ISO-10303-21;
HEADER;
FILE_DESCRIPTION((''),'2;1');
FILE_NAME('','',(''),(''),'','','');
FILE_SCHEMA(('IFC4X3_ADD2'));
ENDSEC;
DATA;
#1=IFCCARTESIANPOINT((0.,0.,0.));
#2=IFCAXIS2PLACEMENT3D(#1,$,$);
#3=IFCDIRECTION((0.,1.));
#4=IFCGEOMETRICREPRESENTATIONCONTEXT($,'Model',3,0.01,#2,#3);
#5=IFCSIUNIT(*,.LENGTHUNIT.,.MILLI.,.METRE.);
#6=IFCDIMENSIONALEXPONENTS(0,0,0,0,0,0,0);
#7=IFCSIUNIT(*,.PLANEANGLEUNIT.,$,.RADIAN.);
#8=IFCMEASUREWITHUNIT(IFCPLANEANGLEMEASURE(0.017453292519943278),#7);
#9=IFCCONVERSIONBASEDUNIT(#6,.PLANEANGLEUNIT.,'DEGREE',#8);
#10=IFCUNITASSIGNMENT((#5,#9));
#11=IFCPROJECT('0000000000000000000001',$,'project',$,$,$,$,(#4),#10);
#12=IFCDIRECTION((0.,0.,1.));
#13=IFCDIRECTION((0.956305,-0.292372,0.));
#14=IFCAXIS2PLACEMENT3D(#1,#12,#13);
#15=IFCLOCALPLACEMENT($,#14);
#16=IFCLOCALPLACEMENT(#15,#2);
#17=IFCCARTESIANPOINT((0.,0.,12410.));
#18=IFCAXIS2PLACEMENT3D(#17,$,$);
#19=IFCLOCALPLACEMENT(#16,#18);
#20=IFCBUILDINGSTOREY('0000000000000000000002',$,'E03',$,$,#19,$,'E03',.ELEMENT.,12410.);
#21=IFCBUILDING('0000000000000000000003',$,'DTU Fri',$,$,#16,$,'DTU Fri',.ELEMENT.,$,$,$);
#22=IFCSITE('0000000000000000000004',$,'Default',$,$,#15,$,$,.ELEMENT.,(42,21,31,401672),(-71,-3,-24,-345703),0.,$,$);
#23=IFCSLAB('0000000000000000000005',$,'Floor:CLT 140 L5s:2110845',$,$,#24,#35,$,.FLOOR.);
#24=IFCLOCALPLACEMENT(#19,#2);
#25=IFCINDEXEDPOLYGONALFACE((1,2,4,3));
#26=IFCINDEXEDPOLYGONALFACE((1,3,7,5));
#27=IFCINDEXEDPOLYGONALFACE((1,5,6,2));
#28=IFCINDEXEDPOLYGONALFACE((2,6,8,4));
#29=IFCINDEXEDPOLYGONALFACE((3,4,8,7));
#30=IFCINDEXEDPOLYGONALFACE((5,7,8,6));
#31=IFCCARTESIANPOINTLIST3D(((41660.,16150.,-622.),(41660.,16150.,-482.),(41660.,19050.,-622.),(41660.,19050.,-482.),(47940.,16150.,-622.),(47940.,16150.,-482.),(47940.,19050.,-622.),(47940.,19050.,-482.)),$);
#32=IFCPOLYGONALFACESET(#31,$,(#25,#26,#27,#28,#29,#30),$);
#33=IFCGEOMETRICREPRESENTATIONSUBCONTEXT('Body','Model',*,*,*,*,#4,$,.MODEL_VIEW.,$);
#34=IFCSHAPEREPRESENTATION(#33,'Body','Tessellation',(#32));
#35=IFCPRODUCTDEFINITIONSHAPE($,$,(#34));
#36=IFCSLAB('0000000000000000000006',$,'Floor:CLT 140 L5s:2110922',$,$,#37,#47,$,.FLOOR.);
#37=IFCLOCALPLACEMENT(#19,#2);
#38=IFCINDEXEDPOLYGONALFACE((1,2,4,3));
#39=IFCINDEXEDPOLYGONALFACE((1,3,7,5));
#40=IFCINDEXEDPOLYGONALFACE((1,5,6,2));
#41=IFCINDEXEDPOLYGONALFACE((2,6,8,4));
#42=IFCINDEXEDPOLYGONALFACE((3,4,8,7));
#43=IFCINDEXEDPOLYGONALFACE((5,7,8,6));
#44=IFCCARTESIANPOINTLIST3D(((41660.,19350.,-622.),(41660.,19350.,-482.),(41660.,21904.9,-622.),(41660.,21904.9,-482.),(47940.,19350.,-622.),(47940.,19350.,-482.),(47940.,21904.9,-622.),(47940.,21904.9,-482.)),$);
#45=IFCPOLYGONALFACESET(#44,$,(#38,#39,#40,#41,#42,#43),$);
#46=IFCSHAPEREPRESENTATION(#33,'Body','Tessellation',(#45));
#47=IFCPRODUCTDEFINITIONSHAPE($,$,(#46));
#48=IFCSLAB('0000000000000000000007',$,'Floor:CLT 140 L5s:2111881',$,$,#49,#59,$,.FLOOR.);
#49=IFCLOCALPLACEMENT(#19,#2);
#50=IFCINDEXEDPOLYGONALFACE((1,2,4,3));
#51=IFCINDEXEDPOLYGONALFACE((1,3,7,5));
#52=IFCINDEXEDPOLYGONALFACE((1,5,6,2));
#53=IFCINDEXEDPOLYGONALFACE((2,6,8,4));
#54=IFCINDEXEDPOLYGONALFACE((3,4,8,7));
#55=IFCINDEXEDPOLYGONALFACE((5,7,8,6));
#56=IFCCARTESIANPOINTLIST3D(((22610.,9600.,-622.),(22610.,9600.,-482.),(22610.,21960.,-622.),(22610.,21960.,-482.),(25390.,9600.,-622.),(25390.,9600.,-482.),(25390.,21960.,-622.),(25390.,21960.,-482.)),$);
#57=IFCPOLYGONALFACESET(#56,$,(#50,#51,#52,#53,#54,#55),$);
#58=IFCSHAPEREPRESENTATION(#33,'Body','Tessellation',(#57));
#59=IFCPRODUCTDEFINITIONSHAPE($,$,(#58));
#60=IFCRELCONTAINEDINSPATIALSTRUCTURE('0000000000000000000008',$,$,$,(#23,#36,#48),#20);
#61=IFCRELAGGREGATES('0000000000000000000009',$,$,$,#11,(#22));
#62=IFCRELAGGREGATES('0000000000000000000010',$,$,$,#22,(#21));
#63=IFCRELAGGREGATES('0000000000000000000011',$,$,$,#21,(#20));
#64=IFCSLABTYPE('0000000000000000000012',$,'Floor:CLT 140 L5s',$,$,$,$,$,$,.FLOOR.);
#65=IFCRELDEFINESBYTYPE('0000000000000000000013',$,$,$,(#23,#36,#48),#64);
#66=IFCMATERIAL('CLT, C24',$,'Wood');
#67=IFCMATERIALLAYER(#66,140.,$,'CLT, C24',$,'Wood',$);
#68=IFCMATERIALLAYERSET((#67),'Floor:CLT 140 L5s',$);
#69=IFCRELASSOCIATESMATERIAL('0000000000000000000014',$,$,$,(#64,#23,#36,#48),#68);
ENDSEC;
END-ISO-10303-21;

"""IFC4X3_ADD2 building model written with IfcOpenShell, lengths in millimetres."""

from ifc_helpers import new_model, entity, si_unit, converted_unit, direction, frame, frame_2d, origin, origin_2d_with_axis, place, context, subcontext, project, spatial, rectangle, extrude, material, layer, layer_set, layer_usage, type_object, element, save


model = new_model("IFC4X3_ADD2")

# Units and contexts
model_context = context("Model", 3, precision=0.01, world=origin(), true_north=direction((0.0, 1.0)))
body_context = subcontext(model_context, "Body", "Model", "MODEL_VIEW")
ifc_project = project(units=[si_unit("LENGTHUNIT", "METRE", prefix="MILLI"), converted_unit("PLANEANGLEUNIT", "DEGREE", entity("IfcPlaneAngleMeasure", 0.017453292519943278), si_unit("PLANEANGLEUNIT", "RADIAN"), dimensions=[0, 0, 0, 0, 0, 0, 0])], contexts=[model_context])

# Site, building, storey
site_placement = place(None, frame((0.0, 0.0, 0.0), z_axis=(0.0, 0.0, 1.0), x_axis=(0.956305, -0.292372, 0.0)))
site = spatial("IfcSite", under=ifc_project, at=site_placement, Name="Default", CompositionType="ELEMENT", RefLatitude=(42, 21, 31, 401672), RefLongitude=(-71, -3, -24, -345703), RefElevation=0.0)
building_placement = place(site_placement, origin())
building = spatial("IfcBuilding", under=site, at=building_placement, Name="DTU Fri", LongName="DTU Fri", CompositionType="ELEMENT")
storey_placement = place(building_placement, frame((0.0, 0.0, 12410.0)))
storey = spatial("IfcBuildingStorey", under=building, at=storey_placement, Name="E03", LongName="E03", CompositionType="ELEMENT", Elevation=12410.0)

# Slabs
ifc_material = material(Name="CLT, C24", Category="Wood")
ifc_layer_1 = layer(ifc_material, 140.0, Name="CLT, C24", Category="Wood")
ifc_layer_set_1 = layer_set([ifc_layer_1], Name="Floor:CLT 140 L5s")
slab_type_1 = type_object("IfcSlabType", Name="Floor:CLT 140 L5s", PredefinedType="FLOOR", material=ifc_layer_set_1)
ifc_layer_usage_1 = layer_usage(ifc_layer_set_1, "AXIS3", "POSITIVE", 0.0)
slab_1_placement = place(storey_placement, origin())
element("IfcSlab", 1, at=slab_1_placement, inside=storey, type_object=slab_type_1, material=ifc_layer_usage_1, Name="Floor:CLT 140 L5s:2110845", PredefinedType="FLOOR", context=body_context, shape_type="SweptSolid", body=[
    extrude(rectangle(XDim=2900.0, YDim=6280.0, at=frame_2d((0.0, 0.0), x_axis=(1.0, 0.0))), frame((44800.0, 17600.0, -482.0), z_axis=(0.0, 0.0, -1.0), x_axis=(0.0, 1.0, 0.0)), (0.0, 0.0, 1.0), 140.0),
])
ifc_layer_usage_2 = layer_usage(ifc_layer_set_1, "AXIS3", "POSITIVE", 0.0)
slab_2_placement = place(storey_placement, origin())
element("IfcSlab", 2, at=slab_2_placement, inside=storey, type_object=slab_type_1, material=ifc_layer_usage_2, Name="Floor:CLT 140 L5s:2110922", PredefinedType="FLOOR", context=body_context, shape_type="SweptSolid", body=[
    extrude(rectangle(XDim=2554.9, YDim=6280.0, at=origin_2d_with_axis()), frame((44800.0, 20627.4, -482.0), z_axis=(0.0, 0.0, -1.0), x_axis=(0.0, 1.0, 0.0)), (0.0, 0.0, 1.0), 140.0),
])
ifc_layer_usage_3 = layer_usage(ifc_layer_set_1, "AXIS3", "POSITIVE", 0.0)
slab_3_placement = place(storey_placement, origin())
element("IfcSlab", 3, at=slab_3_placement, inside=storey, type_object=slab_type_1, material=ifc_layer_usage_3, Name="Floor:CLT 140 L5s:2111881", PredefinedType="FLOOR", context=body_context, shape_type="SweptSolid", body=[
    extrude(rectangle(XDim=12360.0, YDim=2780.0, at=origin_2d_with_axis()), frame((24000.0, 15780.0, -482.0), z_axis=(0.0, 0.0, -1.0), x_axis=(0.0, 1.0, 0.0)), (0.0, 0.0, 1.0), 140.0),
])

save(model, "model.ifc")
